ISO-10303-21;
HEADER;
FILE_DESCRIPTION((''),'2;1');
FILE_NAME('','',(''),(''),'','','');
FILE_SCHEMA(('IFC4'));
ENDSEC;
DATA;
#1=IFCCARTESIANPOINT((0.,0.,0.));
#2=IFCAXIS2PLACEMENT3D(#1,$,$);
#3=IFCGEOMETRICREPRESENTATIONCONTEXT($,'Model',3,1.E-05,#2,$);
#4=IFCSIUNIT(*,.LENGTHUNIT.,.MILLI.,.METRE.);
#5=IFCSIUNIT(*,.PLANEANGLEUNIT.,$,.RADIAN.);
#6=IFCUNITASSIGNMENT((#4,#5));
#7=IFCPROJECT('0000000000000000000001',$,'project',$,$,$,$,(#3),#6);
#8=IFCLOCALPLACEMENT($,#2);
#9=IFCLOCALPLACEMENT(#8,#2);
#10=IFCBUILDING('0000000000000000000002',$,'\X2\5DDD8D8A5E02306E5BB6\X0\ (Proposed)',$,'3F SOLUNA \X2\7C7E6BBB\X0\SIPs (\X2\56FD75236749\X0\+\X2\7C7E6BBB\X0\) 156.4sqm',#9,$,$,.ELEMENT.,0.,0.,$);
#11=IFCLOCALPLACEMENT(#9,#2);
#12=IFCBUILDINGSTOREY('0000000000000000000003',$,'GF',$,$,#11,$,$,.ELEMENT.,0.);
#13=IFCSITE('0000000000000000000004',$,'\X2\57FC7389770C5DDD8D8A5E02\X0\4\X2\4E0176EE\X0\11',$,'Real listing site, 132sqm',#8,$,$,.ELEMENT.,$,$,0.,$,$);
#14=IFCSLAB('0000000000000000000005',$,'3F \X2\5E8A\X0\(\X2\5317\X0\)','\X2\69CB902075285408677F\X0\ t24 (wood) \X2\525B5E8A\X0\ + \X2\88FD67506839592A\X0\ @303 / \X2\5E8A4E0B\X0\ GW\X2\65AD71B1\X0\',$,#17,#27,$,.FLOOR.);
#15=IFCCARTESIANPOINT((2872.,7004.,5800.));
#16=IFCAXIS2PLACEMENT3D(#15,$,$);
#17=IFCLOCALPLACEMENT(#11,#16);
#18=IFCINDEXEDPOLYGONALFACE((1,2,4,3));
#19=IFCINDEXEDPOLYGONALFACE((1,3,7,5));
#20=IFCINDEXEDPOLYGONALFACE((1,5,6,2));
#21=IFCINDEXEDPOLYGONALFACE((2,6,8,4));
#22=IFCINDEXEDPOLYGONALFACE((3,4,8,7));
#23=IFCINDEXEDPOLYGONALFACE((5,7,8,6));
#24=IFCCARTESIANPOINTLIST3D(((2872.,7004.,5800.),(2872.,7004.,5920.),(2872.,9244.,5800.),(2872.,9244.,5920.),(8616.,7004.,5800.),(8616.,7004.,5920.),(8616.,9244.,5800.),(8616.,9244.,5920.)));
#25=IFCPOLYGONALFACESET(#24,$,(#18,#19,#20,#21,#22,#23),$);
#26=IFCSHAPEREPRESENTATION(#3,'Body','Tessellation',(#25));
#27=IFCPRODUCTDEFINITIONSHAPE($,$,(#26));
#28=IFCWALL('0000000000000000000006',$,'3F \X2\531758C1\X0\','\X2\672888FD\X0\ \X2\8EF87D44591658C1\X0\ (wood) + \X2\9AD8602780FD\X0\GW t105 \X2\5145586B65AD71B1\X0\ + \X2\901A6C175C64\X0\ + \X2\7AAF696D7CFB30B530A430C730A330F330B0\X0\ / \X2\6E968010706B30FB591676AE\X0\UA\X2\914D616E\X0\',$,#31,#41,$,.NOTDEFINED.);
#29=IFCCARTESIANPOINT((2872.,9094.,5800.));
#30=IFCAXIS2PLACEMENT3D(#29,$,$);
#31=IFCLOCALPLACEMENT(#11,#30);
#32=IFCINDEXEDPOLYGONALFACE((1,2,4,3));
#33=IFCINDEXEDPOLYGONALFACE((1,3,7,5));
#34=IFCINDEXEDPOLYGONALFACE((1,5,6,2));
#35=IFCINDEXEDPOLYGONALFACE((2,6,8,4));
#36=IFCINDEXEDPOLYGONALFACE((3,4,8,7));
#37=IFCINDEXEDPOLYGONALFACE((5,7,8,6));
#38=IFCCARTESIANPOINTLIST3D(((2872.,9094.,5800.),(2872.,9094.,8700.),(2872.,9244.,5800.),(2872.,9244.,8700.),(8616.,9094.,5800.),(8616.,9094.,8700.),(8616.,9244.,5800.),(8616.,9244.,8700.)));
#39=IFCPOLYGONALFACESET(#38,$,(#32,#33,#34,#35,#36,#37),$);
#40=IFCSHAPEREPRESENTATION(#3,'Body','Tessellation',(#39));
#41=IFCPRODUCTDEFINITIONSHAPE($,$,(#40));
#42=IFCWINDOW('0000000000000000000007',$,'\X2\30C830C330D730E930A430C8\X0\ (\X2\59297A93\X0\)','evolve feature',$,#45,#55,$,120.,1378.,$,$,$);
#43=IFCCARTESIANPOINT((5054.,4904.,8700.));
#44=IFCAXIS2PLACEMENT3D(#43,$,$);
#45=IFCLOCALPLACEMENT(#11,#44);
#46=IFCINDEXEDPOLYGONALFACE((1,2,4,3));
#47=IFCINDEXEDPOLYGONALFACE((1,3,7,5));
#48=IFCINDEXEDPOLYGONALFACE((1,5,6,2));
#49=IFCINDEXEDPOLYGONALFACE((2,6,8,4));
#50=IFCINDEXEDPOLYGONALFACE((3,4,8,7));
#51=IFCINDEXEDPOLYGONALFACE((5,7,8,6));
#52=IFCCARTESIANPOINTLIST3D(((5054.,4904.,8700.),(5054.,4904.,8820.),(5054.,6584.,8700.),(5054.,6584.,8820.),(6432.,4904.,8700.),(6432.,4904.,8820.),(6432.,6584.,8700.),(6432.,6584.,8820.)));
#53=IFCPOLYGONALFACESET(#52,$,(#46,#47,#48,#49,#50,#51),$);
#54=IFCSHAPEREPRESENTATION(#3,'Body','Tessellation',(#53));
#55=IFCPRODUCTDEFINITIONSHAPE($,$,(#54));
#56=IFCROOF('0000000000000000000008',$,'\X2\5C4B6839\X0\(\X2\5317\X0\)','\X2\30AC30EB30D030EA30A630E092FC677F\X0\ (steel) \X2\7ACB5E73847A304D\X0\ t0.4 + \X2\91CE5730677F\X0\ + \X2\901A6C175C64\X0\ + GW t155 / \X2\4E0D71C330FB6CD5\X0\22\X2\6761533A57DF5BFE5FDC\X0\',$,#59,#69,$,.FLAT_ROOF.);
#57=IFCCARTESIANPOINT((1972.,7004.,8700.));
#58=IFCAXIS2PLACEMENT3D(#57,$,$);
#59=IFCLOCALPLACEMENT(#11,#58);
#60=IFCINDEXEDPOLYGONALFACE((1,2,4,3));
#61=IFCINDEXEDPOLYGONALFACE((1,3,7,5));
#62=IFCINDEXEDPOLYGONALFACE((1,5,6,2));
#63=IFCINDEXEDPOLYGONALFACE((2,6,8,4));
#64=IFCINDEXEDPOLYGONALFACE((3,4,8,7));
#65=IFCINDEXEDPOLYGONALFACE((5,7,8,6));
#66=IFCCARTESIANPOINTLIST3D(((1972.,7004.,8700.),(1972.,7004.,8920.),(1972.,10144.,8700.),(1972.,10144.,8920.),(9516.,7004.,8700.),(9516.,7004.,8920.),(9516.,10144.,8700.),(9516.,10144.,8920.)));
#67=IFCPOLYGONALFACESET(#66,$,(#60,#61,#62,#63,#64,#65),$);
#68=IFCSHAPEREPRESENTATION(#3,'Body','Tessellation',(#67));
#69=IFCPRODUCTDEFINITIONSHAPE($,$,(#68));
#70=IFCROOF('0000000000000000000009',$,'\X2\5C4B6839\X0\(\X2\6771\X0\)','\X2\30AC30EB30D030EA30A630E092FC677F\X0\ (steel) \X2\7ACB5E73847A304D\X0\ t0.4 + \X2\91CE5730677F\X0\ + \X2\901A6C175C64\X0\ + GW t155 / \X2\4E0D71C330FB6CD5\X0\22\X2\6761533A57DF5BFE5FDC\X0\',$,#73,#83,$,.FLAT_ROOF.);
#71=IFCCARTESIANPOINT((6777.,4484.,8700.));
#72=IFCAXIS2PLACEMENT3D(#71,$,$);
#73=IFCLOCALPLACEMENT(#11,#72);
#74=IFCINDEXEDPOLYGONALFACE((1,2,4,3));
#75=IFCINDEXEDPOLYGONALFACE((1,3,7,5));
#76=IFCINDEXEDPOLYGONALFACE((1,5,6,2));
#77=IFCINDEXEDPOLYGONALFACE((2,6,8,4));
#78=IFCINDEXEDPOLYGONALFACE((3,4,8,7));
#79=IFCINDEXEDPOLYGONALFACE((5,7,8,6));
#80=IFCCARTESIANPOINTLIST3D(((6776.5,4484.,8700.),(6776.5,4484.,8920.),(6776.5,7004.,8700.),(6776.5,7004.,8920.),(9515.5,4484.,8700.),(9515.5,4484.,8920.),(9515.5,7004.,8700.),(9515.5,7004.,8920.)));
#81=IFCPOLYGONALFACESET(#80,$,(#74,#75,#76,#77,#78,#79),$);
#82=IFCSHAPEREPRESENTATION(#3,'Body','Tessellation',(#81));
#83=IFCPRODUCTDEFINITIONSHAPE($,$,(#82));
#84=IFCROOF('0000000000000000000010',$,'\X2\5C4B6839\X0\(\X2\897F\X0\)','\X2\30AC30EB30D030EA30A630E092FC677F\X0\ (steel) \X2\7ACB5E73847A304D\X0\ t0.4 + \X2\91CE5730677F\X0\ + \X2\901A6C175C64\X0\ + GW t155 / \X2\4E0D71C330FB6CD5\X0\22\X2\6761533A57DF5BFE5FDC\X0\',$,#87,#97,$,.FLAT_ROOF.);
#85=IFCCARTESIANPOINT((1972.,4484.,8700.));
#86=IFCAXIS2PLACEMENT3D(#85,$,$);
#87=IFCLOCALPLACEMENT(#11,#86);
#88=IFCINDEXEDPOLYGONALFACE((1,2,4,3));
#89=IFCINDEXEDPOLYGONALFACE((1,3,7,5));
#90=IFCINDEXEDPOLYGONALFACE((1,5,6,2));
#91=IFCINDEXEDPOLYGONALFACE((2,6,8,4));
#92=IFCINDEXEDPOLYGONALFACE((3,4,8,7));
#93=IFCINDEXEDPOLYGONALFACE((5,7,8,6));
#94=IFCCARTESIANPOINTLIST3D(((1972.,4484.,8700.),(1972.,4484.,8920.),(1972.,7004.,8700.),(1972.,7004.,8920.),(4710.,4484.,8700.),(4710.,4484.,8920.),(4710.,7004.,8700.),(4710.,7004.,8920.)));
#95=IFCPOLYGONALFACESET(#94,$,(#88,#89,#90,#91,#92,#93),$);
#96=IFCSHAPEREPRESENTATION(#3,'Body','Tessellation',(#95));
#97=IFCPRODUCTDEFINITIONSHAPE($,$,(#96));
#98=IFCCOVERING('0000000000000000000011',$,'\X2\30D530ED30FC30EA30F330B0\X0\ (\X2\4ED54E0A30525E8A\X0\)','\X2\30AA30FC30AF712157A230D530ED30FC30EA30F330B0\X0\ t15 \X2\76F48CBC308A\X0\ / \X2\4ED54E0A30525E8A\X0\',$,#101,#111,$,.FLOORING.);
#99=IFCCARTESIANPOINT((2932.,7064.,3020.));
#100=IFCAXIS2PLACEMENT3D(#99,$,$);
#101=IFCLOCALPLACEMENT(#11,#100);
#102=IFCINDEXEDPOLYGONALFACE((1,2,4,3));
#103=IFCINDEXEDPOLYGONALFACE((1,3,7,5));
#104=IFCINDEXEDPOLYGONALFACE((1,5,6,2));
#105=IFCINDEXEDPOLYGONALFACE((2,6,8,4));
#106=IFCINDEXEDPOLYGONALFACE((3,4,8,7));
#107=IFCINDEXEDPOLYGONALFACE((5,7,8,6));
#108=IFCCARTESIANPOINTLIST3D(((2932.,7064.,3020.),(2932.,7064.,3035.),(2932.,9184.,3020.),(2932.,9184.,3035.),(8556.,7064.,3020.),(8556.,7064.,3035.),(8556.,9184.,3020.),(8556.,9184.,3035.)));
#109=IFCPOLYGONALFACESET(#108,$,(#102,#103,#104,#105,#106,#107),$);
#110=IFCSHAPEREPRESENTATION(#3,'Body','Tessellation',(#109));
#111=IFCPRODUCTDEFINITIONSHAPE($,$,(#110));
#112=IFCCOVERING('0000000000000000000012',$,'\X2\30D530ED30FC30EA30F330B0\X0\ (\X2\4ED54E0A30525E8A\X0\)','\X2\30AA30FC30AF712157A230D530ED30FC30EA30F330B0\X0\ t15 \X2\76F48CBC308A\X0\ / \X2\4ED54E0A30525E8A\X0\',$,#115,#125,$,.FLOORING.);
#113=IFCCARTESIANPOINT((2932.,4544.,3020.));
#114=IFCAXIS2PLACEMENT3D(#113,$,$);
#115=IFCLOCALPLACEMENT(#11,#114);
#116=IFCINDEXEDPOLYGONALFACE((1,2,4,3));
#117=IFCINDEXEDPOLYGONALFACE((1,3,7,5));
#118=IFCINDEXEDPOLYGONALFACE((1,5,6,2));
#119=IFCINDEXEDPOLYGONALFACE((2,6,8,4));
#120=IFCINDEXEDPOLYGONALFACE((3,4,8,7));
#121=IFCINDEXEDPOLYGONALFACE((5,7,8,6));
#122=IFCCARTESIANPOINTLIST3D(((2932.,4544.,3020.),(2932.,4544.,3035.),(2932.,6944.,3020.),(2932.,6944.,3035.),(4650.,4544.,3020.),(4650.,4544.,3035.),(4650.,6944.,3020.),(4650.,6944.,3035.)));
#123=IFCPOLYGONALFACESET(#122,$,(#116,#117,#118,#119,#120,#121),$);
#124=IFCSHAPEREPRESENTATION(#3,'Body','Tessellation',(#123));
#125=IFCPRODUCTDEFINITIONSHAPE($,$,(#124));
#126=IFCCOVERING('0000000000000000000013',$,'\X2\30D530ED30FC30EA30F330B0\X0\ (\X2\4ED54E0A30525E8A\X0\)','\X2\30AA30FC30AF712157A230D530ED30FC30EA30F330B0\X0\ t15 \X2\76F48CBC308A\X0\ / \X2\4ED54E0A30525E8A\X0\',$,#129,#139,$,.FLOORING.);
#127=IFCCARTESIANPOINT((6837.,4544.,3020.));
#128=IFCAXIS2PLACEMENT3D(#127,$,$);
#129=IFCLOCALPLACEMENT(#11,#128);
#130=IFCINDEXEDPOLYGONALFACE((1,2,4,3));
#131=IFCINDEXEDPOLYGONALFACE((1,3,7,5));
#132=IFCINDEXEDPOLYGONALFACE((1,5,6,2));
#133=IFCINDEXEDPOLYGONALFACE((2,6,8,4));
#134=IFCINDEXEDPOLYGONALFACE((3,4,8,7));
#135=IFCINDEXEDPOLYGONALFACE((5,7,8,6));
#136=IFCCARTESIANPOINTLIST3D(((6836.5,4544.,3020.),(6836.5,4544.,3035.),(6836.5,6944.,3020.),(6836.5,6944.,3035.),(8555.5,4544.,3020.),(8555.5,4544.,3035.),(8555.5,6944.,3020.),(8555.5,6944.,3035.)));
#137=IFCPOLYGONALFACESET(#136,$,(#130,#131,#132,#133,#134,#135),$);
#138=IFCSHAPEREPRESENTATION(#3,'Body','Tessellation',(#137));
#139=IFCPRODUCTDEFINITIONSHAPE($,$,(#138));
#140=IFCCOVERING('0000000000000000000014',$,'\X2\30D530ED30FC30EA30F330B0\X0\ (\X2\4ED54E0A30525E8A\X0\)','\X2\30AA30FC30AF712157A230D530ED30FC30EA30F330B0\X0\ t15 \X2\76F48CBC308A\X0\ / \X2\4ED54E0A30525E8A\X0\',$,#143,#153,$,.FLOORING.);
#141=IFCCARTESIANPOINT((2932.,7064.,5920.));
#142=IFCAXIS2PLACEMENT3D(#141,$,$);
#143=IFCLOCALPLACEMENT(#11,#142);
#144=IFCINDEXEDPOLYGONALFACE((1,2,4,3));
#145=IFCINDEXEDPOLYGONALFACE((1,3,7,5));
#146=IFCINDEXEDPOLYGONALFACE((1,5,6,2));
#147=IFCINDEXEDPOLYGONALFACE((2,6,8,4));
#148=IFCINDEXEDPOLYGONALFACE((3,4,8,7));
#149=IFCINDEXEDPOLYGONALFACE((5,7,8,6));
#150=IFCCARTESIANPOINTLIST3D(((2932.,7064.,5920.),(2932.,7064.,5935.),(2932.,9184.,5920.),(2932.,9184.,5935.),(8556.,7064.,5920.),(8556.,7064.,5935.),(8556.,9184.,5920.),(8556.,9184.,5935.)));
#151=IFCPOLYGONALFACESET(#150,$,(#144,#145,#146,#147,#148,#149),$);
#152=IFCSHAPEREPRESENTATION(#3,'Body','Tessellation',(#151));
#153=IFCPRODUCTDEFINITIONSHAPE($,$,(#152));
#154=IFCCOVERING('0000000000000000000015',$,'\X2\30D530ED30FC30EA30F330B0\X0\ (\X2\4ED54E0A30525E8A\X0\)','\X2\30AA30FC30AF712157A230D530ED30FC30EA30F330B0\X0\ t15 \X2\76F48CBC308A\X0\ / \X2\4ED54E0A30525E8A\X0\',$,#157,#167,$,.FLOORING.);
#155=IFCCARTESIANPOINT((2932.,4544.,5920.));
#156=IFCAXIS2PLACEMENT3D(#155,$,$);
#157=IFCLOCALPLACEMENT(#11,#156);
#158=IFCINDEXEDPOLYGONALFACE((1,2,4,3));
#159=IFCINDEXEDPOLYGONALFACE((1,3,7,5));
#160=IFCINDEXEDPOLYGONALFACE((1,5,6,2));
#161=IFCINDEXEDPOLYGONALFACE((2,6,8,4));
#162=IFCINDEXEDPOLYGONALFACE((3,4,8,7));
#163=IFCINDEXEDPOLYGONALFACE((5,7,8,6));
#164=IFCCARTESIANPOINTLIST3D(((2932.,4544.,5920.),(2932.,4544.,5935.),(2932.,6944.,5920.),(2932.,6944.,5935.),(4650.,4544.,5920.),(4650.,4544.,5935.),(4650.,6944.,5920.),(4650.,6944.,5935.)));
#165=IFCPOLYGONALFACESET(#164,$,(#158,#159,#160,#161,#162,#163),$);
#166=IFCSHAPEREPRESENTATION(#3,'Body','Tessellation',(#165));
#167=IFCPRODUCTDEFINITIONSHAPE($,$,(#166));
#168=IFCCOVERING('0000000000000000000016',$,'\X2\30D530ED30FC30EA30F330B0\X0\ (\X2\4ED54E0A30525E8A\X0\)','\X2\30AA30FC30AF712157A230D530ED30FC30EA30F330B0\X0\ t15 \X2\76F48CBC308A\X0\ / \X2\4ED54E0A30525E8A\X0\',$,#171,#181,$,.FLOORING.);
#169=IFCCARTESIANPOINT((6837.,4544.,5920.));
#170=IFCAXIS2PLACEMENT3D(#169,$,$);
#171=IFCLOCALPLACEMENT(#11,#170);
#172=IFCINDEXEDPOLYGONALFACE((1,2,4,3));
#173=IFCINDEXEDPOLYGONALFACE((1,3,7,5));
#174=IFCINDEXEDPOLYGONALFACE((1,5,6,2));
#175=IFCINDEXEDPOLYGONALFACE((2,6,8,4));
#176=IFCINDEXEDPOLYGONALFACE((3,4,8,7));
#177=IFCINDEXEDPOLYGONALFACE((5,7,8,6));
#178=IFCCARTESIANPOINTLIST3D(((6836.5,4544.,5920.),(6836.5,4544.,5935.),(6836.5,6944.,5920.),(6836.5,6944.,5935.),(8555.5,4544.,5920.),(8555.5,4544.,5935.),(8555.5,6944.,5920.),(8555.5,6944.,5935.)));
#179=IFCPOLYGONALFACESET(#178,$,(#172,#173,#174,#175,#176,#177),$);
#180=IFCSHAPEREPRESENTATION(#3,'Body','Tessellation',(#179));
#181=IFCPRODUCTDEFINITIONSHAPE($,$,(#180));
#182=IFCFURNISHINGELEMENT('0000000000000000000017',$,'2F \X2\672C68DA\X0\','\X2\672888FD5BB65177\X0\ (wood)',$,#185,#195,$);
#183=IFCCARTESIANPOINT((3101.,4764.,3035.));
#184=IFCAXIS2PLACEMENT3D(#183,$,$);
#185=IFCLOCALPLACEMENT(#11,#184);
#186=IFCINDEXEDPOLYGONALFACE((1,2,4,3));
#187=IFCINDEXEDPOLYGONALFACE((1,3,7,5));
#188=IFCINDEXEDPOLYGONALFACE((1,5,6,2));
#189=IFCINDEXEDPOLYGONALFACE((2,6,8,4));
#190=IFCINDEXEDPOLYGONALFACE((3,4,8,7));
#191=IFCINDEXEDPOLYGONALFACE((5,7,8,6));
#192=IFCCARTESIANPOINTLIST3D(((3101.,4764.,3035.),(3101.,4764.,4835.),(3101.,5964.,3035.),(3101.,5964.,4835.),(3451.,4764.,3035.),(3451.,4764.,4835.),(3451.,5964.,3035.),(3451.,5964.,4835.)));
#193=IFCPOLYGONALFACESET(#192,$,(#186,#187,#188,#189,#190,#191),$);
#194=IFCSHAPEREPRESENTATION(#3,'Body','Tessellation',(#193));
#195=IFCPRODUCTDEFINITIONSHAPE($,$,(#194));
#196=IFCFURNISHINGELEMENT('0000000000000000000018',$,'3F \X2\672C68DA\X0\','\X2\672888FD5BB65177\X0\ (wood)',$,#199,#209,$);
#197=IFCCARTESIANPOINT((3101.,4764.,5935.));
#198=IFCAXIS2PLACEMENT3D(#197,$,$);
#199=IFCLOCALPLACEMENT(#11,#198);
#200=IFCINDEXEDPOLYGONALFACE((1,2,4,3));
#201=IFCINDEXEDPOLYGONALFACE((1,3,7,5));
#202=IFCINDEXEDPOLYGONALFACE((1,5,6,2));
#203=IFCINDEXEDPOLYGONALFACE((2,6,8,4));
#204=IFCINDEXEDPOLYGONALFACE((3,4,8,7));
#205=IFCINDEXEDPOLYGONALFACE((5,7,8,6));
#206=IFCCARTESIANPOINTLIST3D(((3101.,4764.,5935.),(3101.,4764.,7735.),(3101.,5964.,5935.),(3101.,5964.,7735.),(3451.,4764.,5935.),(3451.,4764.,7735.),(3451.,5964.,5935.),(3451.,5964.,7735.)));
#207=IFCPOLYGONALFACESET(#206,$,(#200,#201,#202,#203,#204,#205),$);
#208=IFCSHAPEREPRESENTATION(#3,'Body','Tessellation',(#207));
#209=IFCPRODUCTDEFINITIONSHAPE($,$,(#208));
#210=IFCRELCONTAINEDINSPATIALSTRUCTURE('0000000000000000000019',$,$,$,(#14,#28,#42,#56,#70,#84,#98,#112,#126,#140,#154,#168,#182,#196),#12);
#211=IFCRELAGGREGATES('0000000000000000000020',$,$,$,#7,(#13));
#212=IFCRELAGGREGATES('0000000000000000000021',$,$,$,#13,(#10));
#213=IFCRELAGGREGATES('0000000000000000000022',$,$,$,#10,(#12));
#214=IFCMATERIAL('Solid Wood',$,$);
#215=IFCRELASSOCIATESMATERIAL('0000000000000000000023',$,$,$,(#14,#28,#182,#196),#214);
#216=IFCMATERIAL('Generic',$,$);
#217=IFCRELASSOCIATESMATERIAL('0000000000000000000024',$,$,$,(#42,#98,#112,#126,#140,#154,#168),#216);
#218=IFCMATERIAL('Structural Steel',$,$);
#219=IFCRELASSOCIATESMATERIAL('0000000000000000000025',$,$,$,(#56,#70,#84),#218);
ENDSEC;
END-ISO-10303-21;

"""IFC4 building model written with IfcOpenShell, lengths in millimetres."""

from ifc_helpers import new_model, si_unit, frame, frame_2d, origin, place, context, project, spatial, rectangle, extrude, material, element, save


model = new_model("IFC4")

# Units and contexts
model_context = context("Model", 3, precision=1e-05, world=origin())
ifc_project = project(units=[si_unit("LENGTHUNIT", "METRE", prefix="MILLI"), si_unit("PLANEANGLEUNIT", "RADIAN")], contexts=[model_context])

# Site, building, storey
site_placement = place(None, origin())
site = spatial("IfcSite", under=ifc_project, at=site_placement, Name="埼玉県川越市4丁目11", ObjectType="Real listing site, 132sqm", CompositionType="ELEMENT", RefElevation=0.0)
building_placement = place(site_placement, origin())
building = spatial("IfcBuilding", under=site, at=building_placement, Name="川越市の家 (Proposed)", ObjectType="3F SOLUNA 籾殻SIPs (国産杉+籾殻) 156.4sqm", CompositionType="ELEMENT", ElevationOfRefHeight=0.0, ElevationOfTerrain=0.0)
storey_placement = place(building_placement, origin())
storey = spatial("IfcBuildingStorey", under=building, at=storey_placement, Name="GF", CompositionType="ELEMENT", Elevation=0.0)

# Slab
ifc_material_1 = material(Name="Solid Wood")
slab_placement = place(storey_placement, frame((2872.0, 7004.0, 5800.0)))
element("IfcSlab", 1, at=slab_placement, inside=storey, material=ifc_material_1, Name="3F 床(北)", Description="構造用合板 t24 (wood) 剛床 + 製材根太 @303 / 床下 GW断熱", PredefinedType="FLOOR", context=model_context, shape_type="SweptSolid", body=[
    extrude(rectangle(XDim=5744.0, YDim=2240.0, at=frame_2d((2872.0, 1120.0))), frame((2872.0, 7004.0, 5800.0)), (0.0, 0.0, 1.0), 120.0),
])

# Wall
wall_1_placement = place(storey_placement, frame((2872.0, 9094.0, 5800.0)))
element("IfcWall", 2, at=wall_1_placement, inside=storey, material=ifc_material_1, Name="3F 北壁", Description="木製 軸組外壁 (wood) + 高性能GW t105 充填断熱 + 通気層 + 窯業系サイディング / 準耐火・外皮UA配慮", PredefinedType="NOTDEFINED", context=model_context, shape_type="SweptSolid", body=[
    extrude(rectangle(XDim=5744.0, YDim=150.0, at=frame_2d((2872.0, 75.0))), frame((2872.0, 9094.0, 5800.0)), (0.0, 0.0, 1.0), 2900.0),
])

# Window
ifc_material_2 = material(Name="Generic")
window_1_placement = place(storey_placement, frame((5054.0, 4904.0, 8700.0)))
element("IfcWindow", 3, at=window_1_placement, inside=storey, material=ifc_material_2, Name="トップライト (天窓)", Description="evolve feature", OverallHeight=120.0, OverallWidth=1378.0, context=model_context, shape_type="SweptSolid", body=[
    extrude(rectangle(XDim=1378.0, YDim=1680.0, at=frame_2d((689.0, 840.0))), frame((5054.0, 4904.0, 8700.0)), (0.0, 0.0, 1.0), 120.0),
])

# Roofs
ifc_material_3 = material(Name="Structural Steel")
roof_1_placement = place(storey_placement, frame((1972.0, 7004.0, 8700.0)))
element("IfcRoof", 4, at=roof_1_placement, inside=storey, material=ifc_material_3, Name="屋根(北)", Description="ガルバリウム鋼板 (steel) 立平葺き t0.4 + 野地板 + 通気層 + GW t155 / 不燃・法22条区域対応", PredefinedType="FLAT_ROOF", context=model_context, shape_type="SweptSolid", body=[
    extrude(rectangle(XDim=7544.0, YDim=3140.0, at=frame_2d((3772.0, 1570.0))), frame((1972.0, 7004.0, 8700.0)), (0.0, 0.0, 1.0), 220.0),
])
roof_2_placement = place(storey_placement, frame((6777.0, 4484.0, 8700.0)))
element("IfcRoof", 5, at=roof_2_placement, inside=storey, material=ifc_material_3, Name="屋根(東)", Description="ガルバリウム鋼板 (steel) 立平葺き t0.4 + 野地板 + 通気層 + GW t155 / 不燃・法22条区域対応", PredefinedType="FLAT_ROOF", context=model_context, shape_type="SweptSolid", body=[
    extrude(rectangle(XDim=2739.0, YDim=2520.0, at=frame_2d((1369.0, 1260.0))), frame((6777.0, 4484.0, 8700.0)), (0.0, 0.0, 1.0), 220.0),
])
roof_3_placement = place(storey_placement, frame((1972.0, 4484.0, 8700.0)))
element("IfcRoof", 6, at=roof_3_placement, inside=storey, material=ifc_material_3, Name="屋根(西)", Description="ガルバリウム鋼板 (steel) 立平葺き t0.4 + 野地板 + 通気層 + GW t155 / 不燃・法22条区域対応", PredefinedType="FLAT_ROOF", context=model_context, shape_type="SweptSolid", body=[
    extrude(rectangle(XDim=2738.0, YDim=2520.0, at=frame_2d((1369.0, 1260.0))), frame((1972.0, 4484.0, 8700.0)), (0.0, 0.0, 1.0), 220.0),
])

# Coverings
covering_1_placement = place(storey_placement, frame((2932.0, 7064.0, 3020.0)))
element("IfcCovering", 7, at=covering_1_placement, inside=storey, material=ifc_material_2, Name="フローリング (仕上げ床)", Description="オーク無垢フローリング t15 直貼り / 仕上げ床", PredefinedType="FLOORING", context=model_context, shape_type="SweptSolid", body=[
    extrude(rectangle(XDim=5624.0, YDim=2120.0, at=frame_2d((2812.0, 1060.0))), frame((2932.0, 7064.0, 3020.0)), (0.0, 0.0, 1.0), 15.0),
])
covering_2_placement = place(storey_placement, frame((2932.0, 4544.0, 3020.0)))
element("IfcCovering", 8, at=covering_2_placement, inside=storey, material=ifc_material_2, Name="フローリング (仕上げ床)", Description="オーク無垢フローリング t15 直貼り / 仕上げ床", PredefinedType="FLOORING", context=model_context, shape_type="SweptSolid", body=[
    extrude(rectangle(XDim=1718.0, YDim=2400.0, at=frame_2d((859.0, 1200.0))), frame((2932.0, 4544.0, 3020.0)), (0.0, 0.0, 1.0), 15.0),
])
covering_3_placement = place(storey_placement, frame((6837.0, 4544.0, 3020.0)))
element("IfcCovering", 9, at=covering_3_placement, inside=storey, material=ifc_material_2, Name="フローリング (仕上げ床)", Description="オーク無垢フローリング t15 直貼り / 仕上げ床", PredefinedType="FLOORING", context=model_context, shape_type="SweptSolid", body=[
    extrude(rectangle(XDim=1719.0, YDim=2400.0, at=frame_2d((859.0, 1200.0))), frame((6837.0, 4544.0, 3020.0)), (0.0, 0.0, 1.0), 15.0),
])
covering_4_placement = place(storey_placement, frame((2932.0, 7064.0, 5920.0)))
element("IfcCovering", 10, at=covering_4_placement, inside=storey, material=ifc_material_2, Name="フローリング (仕上げ床)", Description="オーク無垢フローリング t15 直貼り / 仕上げ床", PredefinedType="FLOORING", context=model_context, shape_type="SweptSolid", body=[
    extrude(rectangle(XDim=5624.0, YDim=2120.0, at=frame_2d((2812.0, 1060.0))), frame((2932.0, 7064.0, 5920.0)), (0.0, 0.0, 1.0), 15.0),
])
covering_5_placement = place(storey_placement, frame((2932.0, 4544.0, 5920.0)))
element("IfcCovering", 11, at=covering_5_placement, inside=storey, material=ifc_material_2, Name="フローリング (仕上げ床)", Description="オーク無垢フローリング t15 直貼り / 仕上げ床", PredefinedType="FLOORING", context=model_context, shape_type="SweptSolid", body=[
    extrude(rectangle(XDim=1718.0, YDim=2400.0, at=frame_2d((859.0, 1200.0))), frame((2932.0, 4544.0, 5920.0)), (0.0, 0.0, 1.0), 15.0),
])
covering_6_placement = place(storey_placement, frame((6837.0, 4544.0, 5920.0)))
element("IfcCovering", 12, at=covering_6_placement, inside=storey, material=ifc_material_2, Name="フローリング (仕上げ床)", Description="オーク無垢フローリング t15 直貼り / 仕上げ床", PredefinedType="FLOORING", context=model_context, shape_type="SweptSolid", body=[
    extrude(rectangle(XDim=1719.0, YDim=2400.0, at=frame_2d((859.0, 1200.0))), frame((6837.0, 4544.0, 5920.0)), (0.0, 0.0, 1.0), 15.0),
])

# Furnishing elements
furnishing_1_placement = place(storey_placement, frame((3101.0, 4764.0, 3035.0)))
element("IfcFurnishingElement", 13, at=furnishing_1_placement, inside=storey, material=ifc_material_1, Name="2F 本棚", Description="木製家具 (wood)", context=model_context, shape_type="SweptSolid", body=[
    extrude(rectangle(XDim=350.0, YDim=1200.0, at=frame_2d((175.0, 600.0))), frame((3101.0, 4764.0, 3035.0)), (0.0, 0.0, 1.0), 1800.0),
])
furnishing_2_placement = place(storey_placement, frame((3101.0, 4764.0, 5935.0)))
element("IfcFurnishingElement", 14, at=furnishing_2_placement, inside=storey, material=ifc_material_1, Name="3F 本棚", Description="木製家具 (wood)", context=model_context, shape_type="SweptSolid", body=[
    extrude(rectangle(XDim=350.0, YDim=1200.0, at=frame_2d((175.0, 600.0))), frame((3101.0, 4764.0, 5935.0)), (0.0, 0.0, 1.0), 1800.0),
])

save(model, "model.ifc")
